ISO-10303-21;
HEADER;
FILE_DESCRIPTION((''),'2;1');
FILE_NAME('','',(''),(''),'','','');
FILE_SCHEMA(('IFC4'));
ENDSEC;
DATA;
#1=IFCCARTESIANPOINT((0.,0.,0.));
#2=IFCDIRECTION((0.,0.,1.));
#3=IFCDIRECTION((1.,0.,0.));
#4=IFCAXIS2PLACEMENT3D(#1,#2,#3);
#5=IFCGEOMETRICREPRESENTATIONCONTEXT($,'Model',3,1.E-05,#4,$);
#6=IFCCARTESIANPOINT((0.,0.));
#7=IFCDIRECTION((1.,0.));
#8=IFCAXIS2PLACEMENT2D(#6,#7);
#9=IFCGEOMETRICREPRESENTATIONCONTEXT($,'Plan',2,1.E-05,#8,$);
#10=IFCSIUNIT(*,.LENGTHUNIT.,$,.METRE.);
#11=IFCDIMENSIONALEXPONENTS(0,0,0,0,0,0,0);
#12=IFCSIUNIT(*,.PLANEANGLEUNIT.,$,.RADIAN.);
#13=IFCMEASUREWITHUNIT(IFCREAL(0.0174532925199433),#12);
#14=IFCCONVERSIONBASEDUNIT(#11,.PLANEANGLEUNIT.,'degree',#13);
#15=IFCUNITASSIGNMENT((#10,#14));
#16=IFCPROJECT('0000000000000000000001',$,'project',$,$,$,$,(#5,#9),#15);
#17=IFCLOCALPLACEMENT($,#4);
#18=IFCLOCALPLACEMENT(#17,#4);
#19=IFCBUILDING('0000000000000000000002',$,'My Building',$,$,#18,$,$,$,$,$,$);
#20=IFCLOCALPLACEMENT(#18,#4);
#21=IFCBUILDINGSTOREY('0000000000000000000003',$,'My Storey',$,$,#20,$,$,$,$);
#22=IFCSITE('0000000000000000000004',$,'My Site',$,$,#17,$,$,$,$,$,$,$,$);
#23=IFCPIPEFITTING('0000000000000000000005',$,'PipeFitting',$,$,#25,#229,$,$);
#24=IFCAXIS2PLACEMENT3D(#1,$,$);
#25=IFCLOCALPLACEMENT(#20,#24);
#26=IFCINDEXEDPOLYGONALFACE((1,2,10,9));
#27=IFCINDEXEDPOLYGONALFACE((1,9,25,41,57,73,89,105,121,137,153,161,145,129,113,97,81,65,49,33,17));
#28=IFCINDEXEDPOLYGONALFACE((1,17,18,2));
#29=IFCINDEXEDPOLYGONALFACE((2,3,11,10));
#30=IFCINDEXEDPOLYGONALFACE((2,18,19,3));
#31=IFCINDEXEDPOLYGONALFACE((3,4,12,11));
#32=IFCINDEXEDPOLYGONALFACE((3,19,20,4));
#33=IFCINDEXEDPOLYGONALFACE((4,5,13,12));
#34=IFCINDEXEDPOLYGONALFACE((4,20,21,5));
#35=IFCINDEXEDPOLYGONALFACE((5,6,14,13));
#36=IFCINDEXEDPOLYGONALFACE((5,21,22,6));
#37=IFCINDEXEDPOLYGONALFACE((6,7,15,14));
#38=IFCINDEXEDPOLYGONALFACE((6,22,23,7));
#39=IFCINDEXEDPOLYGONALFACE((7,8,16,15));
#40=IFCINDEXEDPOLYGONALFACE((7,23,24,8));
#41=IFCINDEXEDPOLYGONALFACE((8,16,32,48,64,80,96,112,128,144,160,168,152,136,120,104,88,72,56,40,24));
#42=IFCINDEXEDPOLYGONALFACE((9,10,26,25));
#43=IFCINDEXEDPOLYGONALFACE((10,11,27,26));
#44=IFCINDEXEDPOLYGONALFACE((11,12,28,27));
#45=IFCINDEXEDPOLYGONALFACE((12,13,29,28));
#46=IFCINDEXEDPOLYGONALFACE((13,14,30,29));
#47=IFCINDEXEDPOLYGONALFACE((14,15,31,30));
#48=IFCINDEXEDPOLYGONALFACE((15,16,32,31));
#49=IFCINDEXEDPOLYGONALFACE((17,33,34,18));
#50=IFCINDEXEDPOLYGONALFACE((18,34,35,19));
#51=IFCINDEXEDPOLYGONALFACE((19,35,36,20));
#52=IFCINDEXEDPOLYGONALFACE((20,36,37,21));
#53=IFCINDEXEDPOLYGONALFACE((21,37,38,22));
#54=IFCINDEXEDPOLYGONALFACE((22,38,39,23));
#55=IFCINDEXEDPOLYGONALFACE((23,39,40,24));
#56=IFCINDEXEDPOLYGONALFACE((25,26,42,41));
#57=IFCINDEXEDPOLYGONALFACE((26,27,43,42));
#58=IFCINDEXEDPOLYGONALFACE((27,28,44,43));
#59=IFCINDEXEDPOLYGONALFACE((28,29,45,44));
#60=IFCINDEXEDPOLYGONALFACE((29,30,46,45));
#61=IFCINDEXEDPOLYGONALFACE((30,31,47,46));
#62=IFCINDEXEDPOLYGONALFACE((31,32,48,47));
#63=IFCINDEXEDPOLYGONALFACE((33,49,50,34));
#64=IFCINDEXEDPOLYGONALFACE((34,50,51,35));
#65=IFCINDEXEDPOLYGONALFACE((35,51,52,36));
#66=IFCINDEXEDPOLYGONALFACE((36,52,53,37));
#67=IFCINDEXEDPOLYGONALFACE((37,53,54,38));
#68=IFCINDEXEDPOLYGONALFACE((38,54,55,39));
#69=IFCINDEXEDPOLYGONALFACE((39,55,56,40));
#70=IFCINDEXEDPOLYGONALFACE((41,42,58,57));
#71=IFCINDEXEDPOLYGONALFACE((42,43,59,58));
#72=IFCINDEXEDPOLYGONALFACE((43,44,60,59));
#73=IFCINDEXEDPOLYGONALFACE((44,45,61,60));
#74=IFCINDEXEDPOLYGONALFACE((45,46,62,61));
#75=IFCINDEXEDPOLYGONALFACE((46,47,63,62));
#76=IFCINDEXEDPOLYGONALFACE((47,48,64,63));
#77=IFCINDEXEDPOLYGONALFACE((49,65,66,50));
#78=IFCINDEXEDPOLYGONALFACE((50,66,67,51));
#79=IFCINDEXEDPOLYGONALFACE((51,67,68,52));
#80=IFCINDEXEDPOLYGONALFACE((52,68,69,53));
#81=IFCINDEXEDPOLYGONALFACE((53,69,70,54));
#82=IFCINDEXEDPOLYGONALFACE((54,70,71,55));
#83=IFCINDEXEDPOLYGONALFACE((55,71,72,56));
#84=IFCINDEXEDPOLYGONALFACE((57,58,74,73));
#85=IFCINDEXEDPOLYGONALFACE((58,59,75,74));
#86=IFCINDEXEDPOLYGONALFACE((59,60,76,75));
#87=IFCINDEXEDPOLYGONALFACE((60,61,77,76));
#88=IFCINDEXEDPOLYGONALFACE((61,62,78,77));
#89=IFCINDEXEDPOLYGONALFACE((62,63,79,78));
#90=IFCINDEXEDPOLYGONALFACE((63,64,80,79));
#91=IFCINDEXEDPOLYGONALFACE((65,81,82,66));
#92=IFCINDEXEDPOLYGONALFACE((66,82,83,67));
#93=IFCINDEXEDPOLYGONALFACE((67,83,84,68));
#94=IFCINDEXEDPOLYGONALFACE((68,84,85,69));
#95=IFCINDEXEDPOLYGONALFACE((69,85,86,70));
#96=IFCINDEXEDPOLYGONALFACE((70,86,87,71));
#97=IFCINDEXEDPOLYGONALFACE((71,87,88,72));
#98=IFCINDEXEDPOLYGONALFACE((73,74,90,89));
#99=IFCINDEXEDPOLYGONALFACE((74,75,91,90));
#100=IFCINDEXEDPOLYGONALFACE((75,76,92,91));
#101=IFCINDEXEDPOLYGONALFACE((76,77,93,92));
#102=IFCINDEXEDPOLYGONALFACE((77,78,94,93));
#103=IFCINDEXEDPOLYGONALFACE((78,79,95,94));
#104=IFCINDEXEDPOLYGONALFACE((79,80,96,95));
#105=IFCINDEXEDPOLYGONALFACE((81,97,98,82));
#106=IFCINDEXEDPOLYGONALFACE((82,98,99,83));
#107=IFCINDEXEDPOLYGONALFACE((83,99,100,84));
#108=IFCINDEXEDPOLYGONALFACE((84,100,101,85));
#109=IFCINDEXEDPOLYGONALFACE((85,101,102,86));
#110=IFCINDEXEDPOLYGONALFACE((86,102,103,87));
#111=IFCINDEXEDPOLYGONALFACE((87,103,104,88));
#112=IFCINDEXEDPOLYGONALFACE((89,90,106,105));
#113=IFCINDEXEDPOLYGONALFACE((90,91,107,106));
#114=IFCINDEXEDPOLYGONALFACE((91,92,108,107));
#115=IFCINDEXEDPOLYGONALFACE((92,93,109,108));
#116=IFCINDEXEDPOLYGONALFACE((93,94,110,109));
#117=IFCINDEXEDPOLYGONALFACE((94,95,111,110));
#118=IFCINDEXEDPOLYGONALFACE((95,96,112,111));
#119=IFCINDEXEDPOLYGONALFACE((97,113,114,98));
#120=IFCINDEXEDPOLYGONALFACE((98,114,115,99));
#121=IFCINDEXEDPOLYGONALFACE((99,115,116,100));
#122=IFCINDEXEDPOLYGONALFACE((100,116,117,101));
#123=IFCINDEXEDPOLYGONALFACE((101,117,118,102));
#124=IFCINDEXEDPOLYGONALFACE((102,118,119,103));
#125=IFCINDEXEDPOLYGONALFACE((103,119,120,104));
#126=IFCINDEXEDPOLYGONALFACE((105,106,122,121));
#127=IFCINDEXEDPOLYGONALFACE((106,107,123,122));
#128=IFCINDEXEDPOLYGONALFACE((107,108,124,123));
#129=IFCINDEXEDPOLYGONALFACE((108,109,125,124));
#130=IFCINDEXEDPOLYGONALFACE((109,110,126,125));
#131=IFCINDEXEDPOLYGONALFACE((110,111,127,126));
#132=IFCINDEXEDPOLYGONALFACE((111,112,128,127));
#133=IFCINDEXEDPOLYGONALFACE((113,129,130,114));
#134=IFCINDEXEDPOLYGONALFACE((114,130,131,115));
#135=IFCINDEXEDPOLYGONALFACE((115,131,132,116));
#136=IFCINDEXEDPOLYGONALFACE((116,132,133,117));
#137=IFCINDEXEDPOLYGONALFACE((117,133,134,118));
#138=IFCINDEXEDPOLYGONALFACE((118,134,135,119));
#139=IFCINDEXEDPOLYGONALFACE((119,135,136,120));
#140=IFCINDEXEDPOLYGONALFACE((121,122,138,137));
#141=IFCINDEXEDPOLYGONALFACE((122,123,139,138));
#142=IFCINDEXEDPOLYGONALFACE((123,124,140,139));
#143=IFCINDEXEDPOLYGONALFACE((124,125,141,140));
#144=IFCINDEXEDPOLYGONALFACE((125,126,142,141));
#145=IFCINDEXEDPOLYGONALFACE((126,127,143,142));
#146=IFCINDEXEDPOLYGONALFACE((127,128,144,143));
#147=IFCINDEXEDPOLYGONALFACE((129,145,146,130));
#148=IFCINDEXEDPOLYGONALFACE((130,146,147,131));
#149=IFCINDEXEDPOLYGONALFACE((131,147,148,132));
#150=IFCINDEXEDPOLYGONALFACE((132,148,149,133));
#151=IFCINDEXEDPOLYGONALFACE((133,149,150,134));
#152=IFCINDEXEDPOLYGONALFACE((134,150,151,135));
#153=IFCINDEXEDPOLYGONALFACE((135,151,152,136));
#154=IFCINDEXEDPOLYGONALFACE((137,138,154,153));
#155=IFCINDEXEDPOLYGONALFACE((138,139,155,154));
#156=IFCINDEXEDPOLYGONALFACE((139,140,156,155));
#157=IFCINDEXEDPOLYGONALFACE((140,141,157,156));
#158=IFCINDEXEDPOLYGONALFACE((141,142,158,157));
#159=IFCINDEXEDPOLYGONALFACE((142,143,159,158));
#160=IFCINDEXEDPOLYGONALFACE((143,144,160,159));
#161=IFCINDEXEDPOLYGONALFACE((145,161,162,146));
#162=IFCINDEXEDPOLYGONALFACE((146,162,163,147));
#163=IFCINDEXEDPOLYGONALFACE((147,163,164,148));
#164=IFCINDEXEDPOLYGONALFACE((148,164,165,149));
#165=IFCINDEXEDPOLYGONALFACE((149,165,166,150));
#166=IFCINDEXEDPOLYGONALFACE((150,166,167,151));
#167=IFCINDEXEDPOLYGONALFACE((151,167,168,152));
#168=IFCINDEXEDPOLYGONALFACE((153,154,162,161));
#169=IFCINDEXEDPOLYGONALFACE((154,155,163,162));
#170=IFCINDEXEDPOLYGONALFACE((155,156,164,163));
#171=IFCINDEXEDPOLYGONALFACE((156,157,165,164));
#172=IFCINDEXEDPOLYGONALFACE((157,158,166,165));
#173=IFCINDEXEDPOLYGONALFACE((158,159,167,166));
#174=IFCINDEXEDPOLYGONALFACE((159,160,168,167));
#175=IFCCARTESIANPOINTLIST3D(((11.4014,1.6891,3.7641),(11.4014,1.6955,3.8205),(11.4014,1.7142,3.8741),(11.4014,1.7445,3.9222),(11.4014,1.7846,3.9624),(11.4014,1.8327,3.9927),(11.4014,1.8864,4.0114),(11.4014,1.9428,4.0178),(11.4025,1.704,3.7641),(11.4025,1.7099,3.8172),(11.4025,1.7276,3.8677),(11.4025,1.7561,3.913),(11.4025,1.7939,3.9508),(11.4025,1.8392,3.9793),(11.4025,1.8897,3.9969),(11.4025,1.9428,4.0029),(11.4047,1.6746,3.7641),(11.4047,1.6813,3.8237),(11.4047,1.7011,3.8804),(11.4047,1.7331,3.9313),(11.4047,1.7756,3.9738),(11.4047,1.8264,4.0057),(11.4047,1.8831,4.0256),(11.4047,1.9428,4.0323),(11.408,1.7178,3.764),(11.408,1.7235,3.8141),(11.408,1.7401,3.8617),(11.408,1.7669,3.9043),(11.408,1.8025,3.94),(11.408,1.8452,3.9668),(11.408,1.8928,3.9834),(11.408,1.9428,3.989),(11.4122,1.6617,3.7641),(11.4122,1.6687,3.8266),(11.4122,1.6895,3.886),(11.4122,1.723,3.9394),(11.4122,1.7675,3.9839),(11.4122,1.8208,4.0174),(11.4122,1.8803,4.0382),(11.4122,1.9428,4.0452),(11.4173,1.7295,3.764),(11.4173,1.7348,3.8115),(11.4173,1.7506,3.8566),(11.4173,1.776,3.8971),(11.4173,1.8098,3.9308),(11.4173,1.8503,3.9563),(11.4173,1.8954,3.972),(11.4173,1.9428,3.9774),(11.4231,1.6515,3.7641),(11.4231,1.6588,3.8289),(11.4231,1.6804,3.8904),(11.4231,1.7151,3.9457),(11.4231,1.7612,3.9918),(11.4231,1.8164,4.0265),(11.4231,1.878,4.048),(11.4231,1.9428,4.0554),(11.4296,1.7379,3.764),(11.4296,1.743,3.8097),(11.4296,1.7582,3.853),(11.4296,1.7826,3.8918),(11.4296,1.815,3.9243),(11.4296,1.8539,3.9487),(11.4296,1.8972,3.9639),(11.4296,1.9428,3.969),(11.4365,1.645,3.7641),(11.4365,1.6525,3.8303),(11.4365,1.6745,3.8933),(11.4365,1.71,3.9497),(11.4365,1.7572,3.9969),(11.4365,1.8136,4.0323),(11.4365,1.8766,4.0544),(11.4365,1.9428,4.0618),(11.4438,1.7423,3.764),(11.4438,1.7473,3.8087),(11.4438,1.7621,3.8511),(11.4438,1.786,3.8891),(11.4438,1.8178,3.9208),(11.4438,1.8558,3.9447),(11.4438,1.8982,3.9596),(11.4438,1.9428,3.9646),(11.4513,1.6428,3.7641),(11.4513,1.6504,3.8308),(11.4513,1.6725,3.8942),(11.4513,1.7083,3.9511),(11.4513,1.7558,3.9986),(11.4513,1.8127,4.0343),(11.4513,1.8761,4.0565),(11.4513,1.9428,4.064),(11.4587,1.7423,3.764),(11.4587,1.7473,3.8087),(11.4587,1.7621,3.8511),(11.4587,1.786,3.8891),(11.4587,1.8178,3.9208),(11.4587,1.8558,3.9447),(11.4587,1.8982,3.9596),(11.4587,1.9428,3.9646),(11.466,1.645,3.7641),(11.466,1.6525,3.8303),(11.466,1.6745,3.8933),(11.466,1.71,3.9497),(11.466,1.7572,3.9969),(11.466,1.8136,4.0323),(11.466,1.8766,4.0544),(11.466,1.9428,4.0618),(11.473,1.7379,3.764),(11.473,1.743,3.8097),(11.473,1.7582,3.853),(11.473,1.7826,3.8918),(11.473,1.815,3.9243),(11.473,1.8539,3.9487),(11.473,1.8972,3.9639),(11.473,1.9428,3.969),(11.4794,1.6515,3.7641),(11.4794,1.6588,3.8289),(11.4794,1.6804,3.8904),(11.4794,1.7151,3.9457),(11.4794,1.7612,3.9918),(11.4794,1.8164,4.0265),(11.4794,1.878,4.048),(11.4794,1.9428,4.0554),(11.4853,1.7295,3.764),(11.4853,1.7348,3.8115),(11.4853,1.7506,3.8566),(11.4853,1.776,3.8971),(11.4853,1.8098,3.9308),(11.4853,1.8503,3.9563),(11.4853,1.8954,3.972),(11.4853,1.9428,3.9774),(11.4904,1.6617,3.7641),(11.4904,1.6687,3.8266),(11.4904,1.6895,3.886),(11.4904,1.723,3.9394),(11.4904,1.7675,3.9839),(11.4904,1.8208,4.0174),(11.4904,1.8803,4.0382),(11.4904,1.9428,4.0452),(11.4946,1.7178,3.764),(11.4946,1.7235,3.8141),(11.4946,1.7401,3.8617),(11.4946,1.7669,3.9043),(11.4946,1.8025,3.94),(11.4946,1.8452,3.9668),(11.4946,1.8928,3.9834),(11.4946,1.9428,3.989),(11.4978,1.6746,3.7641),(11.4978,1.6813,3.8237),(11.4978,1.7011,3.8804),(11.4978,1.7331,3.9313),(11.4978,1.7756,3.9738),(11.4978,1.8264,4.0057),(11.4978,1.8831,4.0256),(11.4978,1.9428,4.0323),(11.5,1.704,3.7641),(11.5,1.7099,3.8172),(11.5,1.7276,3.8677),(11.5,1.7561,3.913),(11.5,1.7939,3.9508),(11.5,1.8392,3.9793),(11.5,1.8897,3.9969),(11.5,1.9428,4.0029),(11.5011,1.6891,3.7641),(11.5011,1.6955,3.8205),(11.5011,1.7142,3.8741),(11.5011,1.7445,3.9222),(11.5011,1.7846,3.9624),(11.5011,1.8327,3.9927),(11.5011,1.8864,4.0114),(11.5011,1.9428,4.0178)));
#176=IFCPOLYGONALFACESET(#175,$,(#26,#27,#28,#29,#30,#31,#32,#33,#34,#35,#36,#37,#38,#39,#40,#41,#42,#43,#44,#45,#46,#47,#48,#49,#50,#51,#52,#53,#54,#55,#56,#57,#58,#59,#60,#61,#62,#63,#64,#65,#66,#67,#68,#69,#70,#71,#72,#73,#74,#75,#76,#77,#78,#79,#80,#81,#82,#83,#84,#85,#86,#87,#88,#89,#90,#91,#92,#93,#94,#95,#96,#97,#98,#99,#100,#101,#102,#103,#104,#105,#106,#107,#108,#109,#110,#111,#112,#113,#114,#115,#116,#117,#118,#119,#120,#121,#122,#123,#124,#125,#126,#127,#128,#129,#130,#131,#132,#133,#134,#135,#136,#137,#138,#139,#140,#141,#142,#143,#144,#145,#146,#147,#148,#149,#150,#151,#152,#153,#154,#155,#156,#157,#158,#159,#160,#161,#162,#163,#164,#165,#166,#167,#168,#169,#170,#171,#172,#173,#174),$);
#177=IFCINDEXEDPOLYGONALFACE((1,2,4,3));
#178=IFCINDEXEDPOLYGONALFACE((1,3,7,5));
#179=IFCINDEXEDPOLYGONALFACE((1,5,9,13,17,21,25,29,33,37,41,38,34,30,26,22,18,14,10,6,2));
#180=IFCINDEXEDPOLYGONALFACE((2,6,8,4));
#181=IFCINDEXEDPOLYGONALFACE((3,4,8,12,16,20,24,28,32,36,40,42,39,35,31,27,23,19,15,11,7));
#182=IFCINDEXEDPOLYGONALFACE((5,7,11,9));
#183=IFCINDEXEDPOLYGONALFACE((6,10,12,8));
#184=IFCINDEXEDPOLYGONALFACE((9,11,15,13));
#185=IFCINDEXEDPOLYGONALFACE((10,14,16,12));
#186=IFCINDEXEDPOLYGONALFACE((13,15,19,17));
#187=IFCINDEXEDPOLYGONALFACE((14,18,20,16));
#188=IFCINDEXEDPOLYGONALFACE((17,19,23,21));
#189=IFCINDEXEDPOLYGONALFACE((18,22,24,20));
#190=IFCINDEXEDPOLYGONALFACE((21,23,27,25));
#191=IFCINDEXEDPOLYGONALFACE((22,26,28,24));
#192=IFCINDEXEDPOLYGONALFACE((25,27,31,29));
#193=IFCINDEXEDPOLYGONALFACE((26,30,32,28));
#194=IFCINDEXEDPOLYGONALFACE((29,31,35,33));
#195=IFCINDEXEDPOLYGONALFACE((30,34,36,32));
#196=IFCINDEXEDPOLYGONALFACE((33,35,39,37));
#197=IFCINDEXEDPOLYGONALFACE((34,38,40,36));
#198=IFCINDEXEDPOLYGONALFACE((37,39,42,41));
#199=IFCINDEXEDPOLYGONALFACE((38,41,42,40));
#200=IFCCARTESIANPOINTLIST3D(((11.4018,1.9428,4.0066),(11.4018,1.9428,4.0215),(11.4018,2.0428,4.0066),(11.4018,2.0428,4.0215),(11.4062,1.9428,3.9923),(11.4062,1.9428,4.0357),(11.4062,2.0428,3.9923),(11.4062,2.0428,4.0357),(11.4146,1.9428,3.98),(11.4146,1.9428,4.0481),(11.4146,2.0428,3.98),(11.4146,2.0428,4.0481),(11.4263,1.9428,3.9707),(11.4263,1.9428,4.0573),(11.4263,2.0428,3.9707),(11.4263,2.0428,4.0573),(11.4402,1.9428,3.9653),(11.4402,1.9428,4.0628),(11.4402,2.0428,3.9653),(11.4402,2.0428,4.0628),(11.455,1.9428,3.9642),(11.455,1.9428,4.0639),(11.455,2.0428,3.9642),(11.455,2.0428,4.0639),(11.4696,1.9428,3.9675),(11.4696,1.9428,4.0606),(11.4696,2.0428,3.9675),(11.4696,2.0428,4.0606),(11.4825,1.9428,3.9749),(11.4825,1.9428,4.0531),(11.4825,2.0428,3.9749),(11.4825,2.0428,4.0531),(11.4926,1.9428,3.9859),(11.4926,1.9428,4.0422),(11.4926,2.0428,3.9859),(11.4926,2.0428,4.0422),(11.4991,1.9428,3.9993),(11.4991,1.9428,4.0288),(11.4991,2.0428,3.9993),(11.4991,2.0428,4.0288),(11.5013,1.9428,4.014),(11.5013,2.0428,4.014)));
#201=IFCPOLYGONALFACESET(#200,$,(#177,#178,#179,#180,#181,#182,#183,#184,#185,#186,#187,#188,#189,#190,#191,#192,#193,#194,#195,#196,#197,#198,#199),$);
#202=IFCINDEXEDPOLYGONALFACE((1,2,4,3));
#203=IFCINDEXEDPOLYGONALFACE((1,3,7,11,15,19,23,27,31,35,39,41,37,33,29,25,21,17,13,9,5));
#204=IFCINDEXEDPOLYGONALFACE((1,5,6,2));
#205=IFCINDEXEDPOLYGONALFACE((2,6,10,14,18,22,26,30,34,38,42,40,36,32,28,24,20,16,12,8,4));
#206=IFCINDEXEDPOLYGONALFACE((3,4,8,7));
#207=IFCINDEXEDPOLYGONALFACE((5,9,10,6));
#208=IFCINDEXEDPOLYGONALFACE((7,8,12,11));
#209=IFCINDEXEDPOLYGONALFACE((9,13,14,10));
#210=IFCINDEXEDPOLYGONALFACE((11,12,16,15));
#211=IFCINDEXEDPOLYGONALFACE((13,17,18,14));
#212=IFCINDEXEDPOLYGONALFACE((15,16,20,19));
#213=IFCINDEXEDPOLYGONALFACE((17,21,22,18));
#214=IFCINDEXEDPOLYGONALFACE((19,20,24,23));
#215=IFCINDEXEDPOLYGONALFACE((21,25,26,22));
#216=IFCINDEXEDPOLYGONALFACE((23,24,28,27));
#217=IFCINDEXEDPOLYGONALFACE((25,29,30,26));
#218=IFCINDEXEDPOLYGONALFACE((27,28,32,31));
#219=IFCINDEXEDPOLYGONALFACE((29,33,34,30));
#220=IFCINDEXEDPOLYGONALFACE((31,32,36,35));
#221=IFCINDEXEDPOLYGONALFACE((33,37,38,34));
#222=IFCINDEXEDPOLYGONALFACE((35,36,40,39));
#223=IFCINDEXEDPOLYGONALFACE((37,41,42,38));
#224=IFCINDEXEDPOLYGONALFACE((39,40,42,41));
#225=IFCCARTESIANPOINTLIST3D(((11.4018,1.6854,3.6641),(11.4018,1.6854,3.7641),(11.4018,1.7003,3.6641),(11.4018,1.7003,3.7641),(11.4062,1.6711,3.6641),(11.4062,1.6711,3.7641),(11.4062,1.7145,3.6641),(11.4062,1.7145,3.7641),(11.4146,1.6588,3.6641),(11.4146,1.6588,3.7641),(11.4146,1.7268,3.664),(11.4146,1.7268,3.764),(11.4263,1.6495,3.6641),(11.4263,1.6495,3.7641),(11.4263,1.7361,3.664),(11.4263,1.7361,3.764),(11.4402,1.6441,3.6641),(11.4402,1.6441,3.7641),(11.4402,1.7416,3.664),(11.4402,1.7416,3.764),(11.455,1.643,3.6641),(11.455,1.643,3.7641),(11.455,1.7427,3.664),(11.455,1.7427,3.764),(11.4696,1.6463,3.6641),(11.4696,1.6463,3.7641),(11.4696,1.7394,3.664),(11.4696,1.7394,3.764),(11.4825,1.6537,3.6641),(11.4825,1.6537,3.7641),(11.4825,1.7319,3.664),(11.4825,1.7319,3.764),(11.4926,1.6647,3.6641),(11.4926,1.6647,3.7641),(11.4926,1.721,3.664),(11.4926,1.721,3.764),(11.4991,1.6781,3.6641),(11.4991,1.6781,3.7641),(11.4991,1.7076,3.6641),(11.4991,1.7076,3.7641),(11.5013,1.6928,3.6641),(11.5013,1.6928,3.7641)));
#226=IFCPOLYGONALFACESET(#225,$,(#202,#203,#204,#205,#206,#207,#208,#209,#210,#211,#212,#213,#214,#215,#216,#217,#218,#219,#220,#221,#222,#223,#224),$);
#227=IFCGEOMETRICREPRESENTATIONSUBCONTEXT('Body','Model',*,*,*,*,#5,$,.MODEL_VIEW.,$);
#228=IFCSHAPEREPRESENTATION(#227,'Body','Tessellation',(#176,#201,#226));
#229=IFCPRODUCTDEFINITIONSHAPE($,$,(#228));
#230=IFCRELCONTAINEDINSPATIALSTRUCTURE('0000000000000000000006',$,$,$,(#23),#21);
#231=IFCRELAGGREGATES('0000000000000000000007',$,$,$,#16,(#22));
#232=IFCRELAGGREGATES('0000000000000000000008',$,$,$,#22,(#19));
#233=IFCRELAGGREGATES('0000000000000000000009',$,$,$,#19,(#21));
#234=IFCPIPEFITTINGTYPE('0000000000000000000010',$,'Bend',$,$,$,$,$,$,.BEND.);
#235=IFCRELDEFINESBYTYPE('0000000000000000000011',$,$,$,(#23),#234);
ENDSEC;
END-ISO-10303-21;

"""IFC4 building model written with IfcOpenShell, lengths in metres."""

from ifc_helpers import new_model, entity, si_unit, converted_unit, frame, origin_with_axes, origin_2d_with_axis, place, context, subcontext, project, spatial, circle, extrude, source, transform, mapped, type_object, type_shapes, element, save


model = new_model("IFC4")

# Units and contexts
model_context = context("Model", 3, precision=1e-05, world=origin_with_axes())
plan_context = context("Plan", 2, precision=1e-05, world=origin_2d_with_axis())
body_context_1 = subcontext(model_context, "Body", "Model", "MODEL_VIEW")
ifc_project = project(units=[si_unit("LENGTHUNIT", "METRE"), converted_unit("PLANEANGLEUNIT", "degree", entity("IfcReal", 0.0174532925199433), si_unit("PLANEANGLEUNIT", "RADIAN"), dimensions=[0, 0, 0, 0, 0, 0, 0])], contexts=[model_context, plan_context])

# Site, building, storey
site_placement = place(None, origin_with_axes())
site = spatial("IfcSite", under=ifc_project, at=site_placement, Name="My Site")
building_placement = place(site_placement, origin_with_axes())
building = spatial("IfcBuilding", under=site, at=building_placement, Name="My Building")
storey_placement = place(building_placement, origin_with_axes())
storey = spatial("IfcBuildingStorey", under=building, at=storey_placement, Name="My Storey")

# Pipe fitting
pipe_fitting_type_1 = type_object("IfcPipeFittingType", Name="Bend", PredefinedType="BEND")
shared_shape_1 = source(origin_with_axes(), body_context_1, "Body", "SolidModel", [
    entity("IfcSweptDiskSolid", entity("IfcIndexedPolyCurve", entity("IfcCartesianPointList3D", [[0.0, 0.0, 0.1], [0.0, -0.0732, 0.2768], [0.0, -0.25, 0.35]]), [entity("IfcArcIndex", [1, 2, 3])]), 0.05),
    extrude(circle(Radius=0.05), origin_with_axes(), (0.0, 0.0, 1.0), 0.1),
    extrude(circle(Radius=0.05), frame((0.0, -0.25, 0.35), z_axis=(0.0, -1.0, 0.000038), x_axis=(1.0, 0.0, 0.0)), (0.0, 0.0, 1.0), 0.1),
])
type_shapes(pipe_fitting_type_1, [shared_shape_1])
for number, where, z_axis, x_axis, name in (
    (1, (11.4513, 2.0428, 4.014), (0.0, -1.0, 0.0), (1.0, 0.0, 0.0), "PipeFitting"),
):
    element("IfcPipeFitting", number, at=place(storey_placement, frame(where, z_axis=z_axis, x_axis=x_axis)), inside=storey, type_object=pipe_fitting_type_1, Name=name, context=body_context_1, shape_type="MappedRepresentation", body=[
        mapped(shared_shape_1, transform((0.0, 0.0, 0.0), x_axis=(1.0, 0.0, 0.0), y_axis=(0.0, 1.0, 0.0), z_axis=(0.0, 0.0, 1.0), scale=1.0)),
    ])

save(model, "model.ifc")
